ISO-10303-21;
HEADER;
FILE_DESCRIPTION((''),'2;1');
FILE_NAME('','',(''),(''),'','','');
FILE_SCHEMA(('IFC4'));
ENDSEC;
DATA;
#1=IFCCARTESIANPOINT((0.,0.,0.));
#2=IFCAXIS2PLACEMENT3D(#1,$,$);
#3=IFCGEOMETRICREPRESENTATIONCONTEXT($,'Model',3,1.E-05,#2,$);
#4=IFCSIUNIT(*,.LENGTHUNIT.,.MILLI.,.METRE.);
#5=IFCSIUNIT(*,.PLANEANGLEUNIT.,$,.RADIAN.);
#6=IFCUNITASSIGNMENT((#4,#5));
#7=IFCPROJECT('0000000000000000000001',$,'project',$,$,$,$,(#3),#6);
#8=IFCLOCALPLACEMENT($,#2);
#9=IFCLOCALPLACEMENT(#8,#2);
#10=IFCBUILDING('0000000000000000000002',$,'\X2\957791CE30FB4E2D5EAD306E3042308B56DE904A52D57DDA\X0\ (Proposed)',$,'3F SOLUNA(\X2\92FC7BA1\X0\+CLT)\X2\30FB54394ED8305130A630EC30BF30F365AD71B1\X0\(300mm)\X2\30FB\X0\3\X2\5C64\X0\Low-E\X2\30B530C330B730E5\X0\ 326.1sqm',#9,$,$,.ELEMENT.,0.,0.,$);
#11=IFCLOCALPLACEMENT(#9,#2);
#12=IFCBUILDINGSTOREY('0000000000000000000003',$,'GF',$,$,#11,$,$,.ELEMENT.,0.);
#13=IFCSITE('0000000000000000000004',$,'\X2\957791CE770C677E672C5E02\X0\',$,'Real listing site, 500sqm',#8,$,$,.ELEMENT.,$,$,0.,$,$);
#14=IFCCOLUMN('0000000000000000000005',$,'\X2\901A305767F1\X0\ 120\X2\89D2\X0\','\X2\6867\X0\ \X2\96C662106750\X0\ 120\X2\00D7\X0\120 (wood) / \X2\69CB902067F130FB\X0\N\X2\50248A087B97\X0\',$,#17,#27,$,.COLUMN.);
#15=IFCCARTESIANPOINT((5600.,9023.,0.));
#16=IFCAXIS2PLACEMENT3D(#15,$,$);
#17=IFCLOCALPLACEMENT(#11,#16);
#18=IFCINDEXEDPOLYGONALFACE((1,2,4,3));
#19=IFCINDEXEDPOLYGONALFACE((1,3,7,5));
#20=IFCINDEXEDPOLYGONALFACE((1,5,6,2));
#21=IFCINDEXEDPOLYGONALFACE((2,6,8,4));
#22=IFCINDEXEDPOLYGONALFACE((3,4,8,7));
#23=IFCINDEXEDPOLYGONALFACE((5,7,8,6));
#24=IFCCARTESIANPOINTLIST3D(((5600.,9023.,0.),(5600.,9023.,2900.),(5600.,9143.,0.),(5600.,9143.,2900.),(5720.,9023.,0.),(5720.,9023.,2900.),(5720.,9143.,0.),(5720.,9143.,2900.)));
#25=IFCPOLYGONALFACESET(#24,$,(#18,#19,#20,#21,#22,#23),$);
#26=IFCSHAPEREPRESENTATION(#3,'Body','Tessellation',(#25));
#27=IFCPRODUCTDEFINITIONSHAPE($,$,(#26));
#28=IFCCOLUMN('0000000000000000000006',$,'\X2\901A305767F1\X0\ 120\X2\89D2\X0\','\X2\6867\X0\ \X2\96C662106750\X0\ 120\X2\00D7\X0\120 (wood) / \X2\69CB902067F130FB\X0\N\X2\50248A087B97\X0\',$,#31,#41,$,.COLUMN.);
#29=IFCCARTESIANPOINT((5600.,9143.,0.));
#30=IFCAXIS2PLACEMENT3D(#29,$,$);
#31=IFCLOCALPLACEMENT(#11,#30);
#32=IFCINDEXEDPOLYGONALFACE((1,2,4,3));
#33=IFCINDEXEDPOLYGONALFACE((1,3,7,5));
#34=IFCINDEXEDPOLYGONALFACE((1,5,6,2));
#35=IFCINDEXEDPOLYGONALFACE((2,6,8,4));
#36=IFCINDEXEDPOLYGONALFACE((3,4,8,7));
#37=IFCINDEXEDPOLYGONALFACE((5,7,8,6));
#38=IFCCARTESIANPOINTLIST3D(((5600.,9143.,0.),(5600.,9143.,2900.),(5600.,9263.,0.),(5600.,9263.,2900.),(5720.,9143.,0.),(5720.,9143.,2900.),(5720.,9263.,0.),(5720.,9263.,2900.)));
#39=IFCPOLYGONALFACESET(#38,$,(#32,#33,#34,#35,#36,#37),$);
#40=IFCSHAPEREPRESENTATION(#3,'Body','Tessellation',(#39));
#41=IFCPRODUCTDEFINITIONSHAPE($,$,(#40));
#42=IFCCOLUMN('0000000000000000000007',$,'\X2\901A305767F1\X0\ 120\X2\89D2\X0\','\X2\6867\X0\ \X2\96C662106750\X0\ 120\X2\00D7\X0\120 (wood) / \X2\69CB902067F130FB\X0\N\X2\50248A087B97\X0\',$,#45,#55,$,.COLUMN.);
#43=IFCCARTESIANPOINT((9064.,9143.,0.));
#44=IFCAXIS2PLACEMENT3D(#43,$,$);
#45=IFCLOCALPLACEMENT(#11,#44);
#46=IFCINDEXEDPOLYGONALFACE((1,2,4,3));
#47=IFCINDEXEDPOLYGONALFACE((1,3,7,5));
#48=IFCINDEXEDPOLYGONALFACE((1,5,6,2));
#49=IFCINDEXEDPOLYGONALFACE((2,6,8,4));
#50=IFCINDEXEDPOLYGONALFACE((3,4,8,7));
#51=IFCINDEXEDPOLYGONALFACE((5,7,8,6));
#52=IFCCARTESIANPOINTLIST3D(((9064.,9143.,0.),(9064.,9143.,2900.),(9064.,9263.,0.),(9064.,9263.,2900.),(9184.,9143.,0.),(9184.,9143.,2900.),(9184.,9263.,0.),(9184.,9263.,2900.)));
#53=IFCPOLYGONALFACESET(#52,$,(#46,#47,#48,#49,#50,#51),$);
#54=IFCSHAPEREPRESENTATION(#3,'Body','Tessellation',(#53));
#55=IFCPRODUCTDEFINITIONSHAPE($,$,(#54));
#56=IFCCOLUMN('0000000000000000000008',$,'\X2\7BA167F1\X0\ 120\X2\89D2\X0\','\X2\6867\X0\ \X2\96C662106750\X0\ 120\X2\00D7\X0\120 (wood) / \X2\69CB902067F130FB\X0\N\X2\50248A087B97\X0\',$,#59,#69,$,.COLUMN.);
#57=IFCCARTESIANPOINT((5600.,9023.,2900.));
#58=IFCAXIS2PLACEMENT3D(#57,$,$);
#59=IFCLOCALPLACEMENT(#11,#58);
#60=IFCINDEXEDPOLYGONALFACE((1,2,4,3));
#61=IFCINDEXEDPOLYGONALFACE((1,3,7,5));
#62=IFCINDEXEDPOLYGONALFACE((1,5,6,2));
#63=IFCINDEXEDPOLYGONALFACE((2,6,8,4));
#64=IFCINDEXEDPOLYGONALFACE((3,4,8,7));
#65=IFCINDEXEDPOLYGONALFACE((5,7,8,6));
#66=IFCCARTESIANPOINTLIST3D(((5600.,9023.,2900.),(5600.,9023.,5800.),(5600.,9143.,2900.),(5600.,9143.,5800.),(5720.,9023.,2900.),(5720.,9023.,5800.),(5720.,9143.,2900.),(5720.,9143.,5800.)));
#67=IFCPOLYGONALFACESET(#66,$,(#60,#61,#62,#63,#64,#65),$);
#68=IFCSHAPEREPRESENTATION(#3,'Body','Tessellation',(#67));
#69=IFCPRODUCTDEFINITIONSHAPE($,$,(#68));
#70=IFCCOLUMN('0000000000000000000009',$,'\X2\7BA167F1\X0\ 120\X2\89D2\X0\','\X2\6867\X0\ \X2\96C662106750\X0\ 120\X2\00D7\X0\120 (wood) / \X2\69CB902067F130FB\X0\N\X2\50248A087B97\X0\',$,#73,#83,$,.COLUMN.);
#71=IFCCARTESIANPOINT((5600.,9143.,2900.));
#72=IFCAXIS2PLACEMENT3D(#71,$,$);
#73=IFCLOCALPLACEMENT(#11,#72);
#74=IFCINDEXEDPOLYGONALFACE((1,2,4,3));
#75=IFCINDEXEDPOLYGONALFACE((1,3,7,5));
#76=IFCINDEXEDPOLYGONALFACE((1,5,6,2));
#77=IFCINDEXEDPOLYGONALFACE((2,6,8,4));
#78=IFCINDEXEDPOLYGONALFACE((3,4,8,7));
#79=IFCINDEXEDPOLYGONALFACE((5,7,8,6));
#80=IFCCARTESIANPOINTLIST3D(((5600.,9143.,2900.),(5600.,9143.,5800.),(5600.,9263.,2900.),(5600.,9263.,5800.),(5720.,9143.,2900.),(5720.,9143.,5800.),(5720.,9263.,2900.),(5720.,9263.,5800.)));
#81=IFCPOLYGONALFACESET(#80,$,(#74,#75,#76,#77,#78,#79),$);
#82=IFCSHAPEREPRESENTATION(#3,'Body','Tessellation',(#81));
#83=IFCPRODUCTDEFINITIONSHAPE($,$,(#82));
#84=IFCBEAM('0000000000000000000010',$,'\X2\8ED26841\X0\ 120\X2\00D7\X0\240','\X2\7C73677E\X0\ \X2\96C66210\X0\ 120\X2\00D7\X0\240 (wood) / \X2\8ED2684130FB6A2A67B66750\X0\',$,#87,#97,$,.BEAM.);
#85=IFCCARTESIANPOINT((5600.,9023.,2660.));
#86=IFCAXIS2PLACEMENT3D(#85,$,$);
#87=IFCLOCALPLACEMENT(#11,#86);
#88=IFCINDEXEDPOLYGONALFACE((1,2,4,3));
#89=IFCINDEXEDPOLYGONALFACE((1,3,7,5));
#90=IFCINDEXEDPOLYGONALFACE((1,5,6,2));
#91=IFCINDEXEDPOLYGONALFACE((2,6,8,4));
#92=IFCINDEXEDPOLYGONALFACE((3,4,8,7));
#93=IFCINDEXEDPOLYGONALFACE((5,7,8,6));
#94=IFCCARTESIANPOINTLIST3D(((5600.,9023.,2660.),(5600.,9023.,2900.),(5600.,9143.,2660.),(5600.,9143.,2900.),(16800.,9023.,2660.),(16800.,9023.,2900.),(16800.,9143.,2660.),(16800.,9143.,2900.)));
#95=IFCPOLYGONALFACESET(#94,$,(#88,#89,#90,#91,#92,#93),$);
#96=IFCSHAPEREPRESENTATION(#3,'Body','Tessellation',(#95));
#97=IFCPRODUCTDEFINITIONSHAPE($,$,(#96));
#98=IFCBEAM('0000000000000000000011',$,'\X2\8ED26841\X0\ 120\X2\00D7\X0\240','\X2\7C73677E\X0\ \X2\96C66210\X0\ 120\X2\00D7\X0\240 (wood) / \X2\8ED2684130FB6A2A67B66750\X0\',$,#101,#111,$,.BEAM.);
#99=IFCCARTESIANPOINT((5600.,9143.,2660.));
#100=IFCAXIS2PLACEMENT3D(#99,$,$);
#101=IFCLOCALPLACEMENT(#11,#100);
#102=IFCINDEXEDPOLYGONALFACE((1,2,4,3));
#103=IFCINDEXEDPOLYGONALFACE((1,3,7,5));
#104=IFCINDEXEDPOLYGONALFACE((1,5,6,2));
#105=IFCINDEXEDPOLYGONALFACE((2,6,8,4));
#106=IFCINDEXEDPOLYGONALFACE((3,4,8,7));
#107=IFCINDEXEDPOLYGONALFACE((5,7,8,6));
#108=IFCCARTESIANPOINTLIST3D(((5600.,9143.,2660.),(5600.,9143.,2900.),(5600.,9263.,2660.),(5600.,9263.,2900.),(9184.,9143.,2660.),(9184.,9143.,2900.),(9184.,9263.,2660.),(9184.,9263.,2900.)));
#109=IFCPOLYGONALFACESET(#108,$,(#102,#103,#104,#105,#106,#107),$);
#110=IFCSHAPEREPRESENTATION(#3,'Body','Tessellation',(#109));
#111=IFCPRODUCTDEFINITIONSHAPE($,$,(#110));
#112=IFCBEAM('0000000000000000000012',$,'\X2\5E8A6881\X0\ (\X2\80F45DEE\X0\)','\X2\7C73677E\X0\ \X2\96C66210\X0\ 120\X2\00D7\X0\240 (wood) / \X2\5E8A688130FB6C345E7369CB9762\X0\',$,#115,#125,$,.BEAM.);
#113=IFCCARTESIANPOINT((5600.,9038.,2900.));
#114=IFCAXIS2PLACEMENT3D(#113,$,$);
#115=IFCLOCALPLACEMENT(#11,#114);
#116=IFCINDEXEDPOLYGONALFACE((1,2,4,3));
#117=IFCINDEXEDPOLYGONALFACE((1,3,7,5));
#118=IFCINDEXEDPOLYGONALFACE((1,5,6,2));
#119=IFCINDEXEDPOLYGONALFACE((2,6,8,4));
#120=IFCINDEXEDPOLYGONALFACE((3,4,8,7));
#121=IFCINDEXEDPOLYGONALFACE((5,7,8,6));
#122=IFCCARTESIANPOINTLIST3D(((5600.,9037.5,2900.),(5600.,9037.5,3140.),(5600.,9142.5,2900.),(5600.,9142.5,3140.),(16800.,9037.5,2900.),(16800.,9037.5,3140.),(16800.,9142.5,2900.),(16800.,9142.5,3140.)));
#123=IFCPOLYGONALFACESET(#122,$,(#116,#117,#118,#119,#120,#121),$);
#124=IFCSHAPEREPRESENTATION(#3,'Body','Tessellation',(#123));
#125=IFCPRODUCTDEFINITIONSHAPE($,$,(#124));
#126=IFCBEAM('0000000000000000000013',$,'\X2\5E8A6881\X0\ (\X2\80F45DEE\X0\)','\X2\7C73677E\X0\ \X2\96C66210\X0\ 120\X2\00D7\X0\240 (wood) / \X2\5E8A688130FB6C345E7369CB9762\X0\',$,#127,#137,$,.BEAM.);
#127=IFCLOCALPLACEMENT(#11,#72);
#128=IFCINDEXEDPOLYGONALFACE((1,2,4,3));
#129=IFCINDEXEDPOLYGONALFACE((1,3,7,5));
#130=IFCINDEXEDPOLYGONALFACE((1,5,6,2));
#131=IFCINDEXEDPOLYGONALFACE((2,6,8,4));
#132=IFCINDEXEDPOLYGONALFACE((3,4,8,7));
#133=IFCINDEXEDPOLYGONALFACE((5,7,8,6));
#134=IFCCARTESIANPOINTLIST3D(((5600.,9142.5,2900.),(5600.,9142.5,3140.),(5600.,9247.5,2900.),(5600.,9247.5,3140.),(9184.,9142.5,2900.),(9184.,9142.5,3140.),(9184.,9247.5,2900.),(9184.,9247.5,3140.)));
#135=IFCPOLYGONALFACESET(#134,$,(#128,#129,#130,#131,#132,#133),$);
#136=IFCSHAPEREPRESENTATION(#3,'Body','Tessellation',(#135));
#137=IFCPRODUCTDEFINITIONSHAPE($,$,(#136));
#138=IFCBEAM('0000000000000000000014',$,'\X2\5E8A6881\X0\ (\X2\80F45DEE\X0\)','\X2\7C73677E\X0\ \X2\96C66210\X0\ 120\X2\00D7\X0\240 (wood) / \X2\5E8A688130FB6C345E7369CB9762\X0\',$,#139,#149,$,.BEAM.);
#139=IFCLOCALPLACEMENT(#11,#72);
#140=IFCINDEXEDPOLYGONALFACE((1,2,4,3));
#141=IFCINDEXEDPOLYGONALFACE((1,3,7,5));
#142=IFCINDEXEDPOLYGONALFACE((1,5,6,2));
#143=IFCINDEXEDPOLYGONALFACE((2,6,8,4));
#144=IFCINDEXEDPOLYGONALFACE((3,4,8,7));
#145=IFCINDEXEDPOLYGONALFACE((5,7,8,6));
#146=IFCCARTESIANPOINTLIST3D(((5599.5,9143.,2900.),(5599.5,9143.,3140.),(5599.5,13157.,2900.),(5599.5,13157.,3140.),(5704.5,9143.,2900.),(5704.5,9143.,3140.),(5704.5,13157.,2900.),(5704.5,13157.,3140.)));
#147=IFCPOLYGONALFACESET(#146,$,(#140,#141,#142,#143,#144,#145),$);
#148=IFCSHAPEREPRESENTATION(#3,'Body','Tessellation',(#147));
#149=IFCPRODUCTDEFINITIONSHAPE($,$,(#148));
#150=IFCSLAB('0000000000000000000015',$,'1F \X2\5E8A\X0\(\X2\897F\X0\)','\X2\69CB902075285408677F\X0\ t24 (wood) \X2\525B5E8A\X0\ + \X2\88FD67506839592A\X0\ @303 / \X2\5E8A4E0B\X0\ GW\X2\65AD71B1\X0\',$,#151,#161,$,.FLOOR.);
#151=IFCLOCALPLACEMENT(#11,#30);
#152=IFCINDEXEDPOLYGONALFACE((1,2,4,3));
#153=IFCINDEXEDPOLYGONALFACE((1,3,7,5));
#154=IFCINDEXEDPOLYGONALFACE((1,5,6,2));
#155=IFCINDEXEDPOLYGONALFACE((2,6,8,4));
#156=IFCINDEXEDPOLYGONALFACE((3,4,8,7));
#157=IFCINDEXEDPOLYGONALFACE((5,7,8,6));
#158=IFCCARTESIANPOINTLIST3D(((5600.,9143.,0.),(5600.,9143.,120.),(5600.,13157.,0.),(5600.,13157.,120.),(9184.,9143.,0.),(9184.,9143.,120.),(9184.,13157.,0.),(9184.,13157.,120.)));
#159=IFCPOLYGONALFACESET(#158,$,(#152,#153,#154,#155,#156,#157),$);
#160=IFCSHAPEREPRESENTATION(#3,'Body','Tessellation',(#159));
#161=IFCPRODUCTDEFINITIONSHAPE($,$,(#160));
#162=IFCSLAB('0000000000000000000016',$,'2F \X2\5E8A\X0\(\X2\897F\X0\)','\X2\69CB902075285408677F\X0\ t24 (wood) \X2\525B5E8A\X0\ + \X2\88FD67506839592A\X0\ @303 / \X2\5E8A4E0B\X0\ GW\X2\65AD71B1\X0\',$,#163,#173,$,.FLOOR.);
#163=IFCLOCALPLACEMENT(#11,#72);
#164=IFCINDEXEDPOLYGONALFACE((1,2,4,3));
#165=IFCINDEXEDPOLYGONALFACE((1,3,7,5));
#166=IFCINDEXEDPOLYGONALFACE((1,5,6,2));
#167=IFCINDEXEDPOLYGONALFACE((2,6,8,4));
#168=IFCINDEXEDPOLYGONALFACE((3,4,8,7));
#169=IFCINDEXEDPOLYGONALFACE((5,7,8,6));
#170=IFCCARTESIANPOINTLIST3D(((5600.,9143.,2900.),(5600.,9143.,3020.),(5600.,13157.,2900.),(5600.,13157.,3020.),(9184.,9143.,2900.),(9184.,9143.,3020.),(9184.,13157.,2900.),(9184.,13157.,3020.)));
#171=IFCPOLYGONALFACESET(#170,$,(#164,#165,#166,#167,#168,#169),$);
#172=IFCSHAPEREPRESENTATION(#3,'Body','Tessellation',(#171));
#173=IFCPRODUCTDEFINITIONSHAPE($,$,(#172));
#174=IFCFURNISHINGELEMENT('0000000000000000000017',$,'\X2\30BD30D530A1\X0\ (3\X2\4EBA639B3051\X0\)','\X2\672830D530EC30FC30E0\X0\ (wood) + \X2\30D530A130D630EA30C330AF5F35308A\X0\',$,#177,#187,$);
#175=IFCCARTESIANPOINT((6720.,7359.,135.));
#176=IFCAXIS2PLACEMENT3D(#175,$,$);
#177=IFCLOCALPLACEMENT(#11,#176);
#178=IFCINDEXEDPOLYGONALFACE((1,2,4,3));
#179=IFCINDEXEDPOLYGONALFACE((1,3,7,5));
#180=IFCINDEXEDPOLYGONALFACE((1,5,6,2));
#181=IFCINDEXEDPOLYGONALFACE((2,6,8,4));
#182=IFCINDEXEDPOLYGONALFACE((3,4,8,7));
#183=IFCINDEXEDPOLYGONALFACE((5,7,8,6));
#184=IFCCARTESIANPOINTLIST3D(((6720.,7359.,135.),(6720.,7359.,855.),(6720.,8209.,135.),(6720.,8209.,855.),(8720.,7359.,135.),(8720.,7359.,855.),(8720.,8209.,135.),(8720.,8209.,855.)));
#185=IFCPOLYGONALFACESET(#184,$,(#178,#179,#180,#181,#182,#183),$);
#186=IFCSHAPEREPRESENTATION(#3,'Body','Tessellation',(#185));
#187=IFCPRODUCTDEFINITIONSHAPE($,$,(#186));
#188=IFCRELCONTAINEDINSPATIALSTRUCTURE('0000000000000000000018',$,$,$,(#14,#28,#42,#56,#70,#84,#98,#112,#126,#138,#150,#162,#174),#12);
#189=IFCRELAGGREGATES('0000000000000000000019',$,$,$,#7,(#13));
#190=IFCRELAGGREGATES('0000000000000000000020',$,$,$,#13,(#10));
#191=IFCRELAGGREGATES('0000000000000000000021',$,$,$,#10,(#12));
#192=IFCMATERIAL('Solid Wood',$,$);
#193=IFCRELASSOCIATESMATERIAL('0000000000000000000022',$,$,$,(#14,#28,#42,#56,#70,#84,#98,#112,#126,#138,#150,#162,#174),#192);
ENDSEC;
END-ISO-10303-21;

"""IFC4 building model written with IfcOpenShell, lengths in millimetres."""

from ifc_helpers import new_model, si_unit, frame, frame_2d, origin, place, context, project, spatial, rectangle, extrude, material, element, save


model = new_model("IFC4")

# Units and contexts
model_context = context("Model", 3, precision=1e-05, world=origin())
ifc_project = project(units=[si_unit("LENGTHUNIT", "METRE", prefix="MILLI"), si_unit("PLANEANGLEUNIT", "RADIAN")], contexts=[model_context])

# Site, building, storey
site_placement = place(None, origin())
site = spatial("IfcSite", under=ifc_project, at=site_placement, Name="長野県松本市", ObjectType="Real listing site, 500sqm", CompositionType="ELEMENT", RefElevation=0.0)
building_placement = place(site_placement, origin())
building = spatial("IfcBuilding", under=site, at=building_placement, Name="長野・中庭のある回遊動線 (Proposed)", ObjectType="3F SOLUNA(鋼管+CLT)・吹付けウレタン断熱(300mm)・3層Low-Eサッシュ 326.1sqm", CompositionType="ELEMENT", ElevationOfRefHeight=0.0, ElevationOfTerrain=0.0)
storey_placement = place(building_placement, origin())
storey = spatial("IfcBuildingStorey", under=building, at=storey_placement, Name="GF", CompositionType="ELEMENT", Elevation=0.0)

# Columns
ifc_material = material(Name="Solid Wood")
column_1_placement = place(storey_placement, frame((5600.0, 9023.0, 0.0)))
element("IfcColumn", 1, at=column_1_placement, inside=storey, material=ifc_material, Name="通し柱 120角", Description="桧 集成材 120×120 (wood) / 構造柱・N値計算", PredefinedType="COLUMN", context=model_context, shape_type="SweptSolid", body=[
    extrude(rectangle(XDim=120.0, YDim=120.0, at=frame_2d((60.0, 60.0))), frame((5600.0, 9023.0, 0.0)), (0.0, 0.0, 1.0), 2900.0),
])
column_2_placement = place(storey_placement, frame((5600.0, 9143.0, 0.0)))
element("IfcColumn", 2, at=column_2_placement, inside=storey, material=ifc_material, Name="通し柱 120角", Description="桧 集成材 120×120 (wood) / 構造柱・N値計算", PredefinedType="COLUMN", context=model_context, shape_type="SweptSolid", body=[
    extrude(rectangle(XDim=120.0, YDim=120.0, at=frame_2d((60.0, 60.0))), frame((5600.0, 9143.0, 0.0)), (0.0, 0.0, 1.0), 2900.0),
])
column_3_placement = place(storey_placement, frame((9064.0, 9143.0, 0.0)))
element("IfcColumn", 3, at=column_3_placement, inside=storey, material=ifc_material, Name="通し柱 120角", Description="桧 集成材 120×120 (wood) / 構造柱・N値計算", PredefinedType="COLUMN", context=model_context, shape_type="SweptSolid", body=[
    extrude(rectangle(XDim=120.0, YDim=120.0, at=frame_2d((60.0, 60.0))), frame((9064.0, 9143.0, 0.0)), (0.0, 0.0, 1.0), 2900.0),
])
column_4_placement = place(storey_placement, frame((5600.0, 9023.0, 2900.0)))
element("IfcColumn", 4, at=column_4_placement, inside=storey, material=ifc_material, Name="管柱 120角", Description="桧 集成材 120×120 (wood) / 構造柱・N値計算", PredefinedType="COLUMN", context=model_context, shape_type="SweptSolid", body=[
    extrude(rectangle(XDim=120.0, YDim=120.0, at=frame_2d((60.0, 60.0))), frame((5600.0, 9023.0, 2900.0)), (0.0, 0.0, 1.0), 2900.0),
])
column_5_placement = place(storey_placement, frame((5600.0, 9143.0, 2900.0)))
element("IfcColumn", 5, at=column_5_placement, inside=storey, material=ifc_material, Name="管柱 120角", Description="桧 集成材 120×120 (wood) / 構造柱・N値計算", PredefinedType="COLUMN", context=model_context, shape_type="SweptSolid", body=[
    extrude(rectangle(XDim=120.0, YDim=120.0, at=frame_2d((60.0, 60.0))), frame((5600.0, 9143.0, 2900.0)), (0.0, 0.0, 1.0), 2900.0),
])

# Beams
beam_1_placement = place(storey_placement, frame((5600.0, 9023.0, 2660.0)))
element("IfcBeam", 6, at=beam_1_placement, inside=storey, material=ifc_material, Name="軒桁 120×240", Description="米松 集成 120×240 (wood) / 軒桁・横架材", PredefinedType="BEAM", context=model_context, shape_type="SweptSolid", body=[
    extrude(rectangle(XDim=11200.0, YDim=120.0, at=frame_2d((5600.0, 60.0))), frame((5600.0, 9023.0, 2660.0)), (0.0, 0.0, 1.0), 240.0),
])
beam_2_placement = place(storey_placement, frame((5600.0, 9143.0, 2660.0)))
element("IfcBeam", 7, at=beam_2_placement, inside=storey, material=ifc_material, Name="軒桁 120×240", Description="米松 集成 120×240 (wood) / 軒桁・横架材", PredefinedType="BEAM", context=model_context, shape_type="SweptSolid", body=[
    extrude(rectangle(XDim=3584.0, YDim=120.0, at=frame_2d((1792.0, 60.0))), frame((5600.0, 9143.0, 2660.0)), (0.0, 0.0, 1.0), 240.0),
])
beam_3_placement = place(storey_placement, frame((5600.0, 9038.0, 2900.0)))
element("IfcBeam", 8, at=beam_3_placement, inside=storey, material=ifc_material, Name="床梁 (胴差)", Description="米松 集成 120×240 (wood) / 床梁・水平構面", PredefinedType="BEAM", context=model_context, shape_type="SweptSolid", body=[
    extrude(rectangle(XDim=11200.0, YDim=105.0, at=frame_2d((5600.0, 52.0))), frame((5600.0, 9038.0, 2900.0)), (0.0, 0.0, 1.0), 240.0),
])
beam_4_placement = place(storey_placement, frame((5600.0, 9143.0, 2900.0)))
element("IfcBeam", 9, at=beam_4_placement, inside=storey, material=ifc_material, Name="床梁 (胴差)", Description="米松 集成 120×240 (wood) / 床梁・水平構面", PredefinedType="BEAM", context=model_context, shape_type="SweptSolid", body=[
    extrude(rectangle(XDim=3584.0, YDim=105.0, at=frame_2d((1792.0, 52.0))), frame((5600.0, 9143.0, 2900.0)), (0.0, 0.0, 1.0), 240.0),
])
beam_5_placement = place(storey_placement, frame((5600.0, 9143.0, 2900.0)))
element("IfcBeam", 10, at=beam_5_placement, inside=storey, material=ifc_material, Name="床梁 (胴差)", Description="米松 集成 120×240 (wood) / 床梁・水平構面", PredefinedType="BEAM", context=model_context, shape_type="SweptSolid", body=[
    extrude(rectangle(XDim=105.0, YDim=4014.0, at=frame_2d((52.0, 2007.0))), frame((5600.0, 9143.0, 2900.0)), (0.0, 0.0, 1.0), 240.0),
])

# Slabs
slab_1_placement = place(storey_placement, frame((5600.0, 9143.0, 0.0)))
element("IfcSlab", 11, at=slab_1_placement, inside=storey, material=ifc_material, Name="1F 床(西)", Description="構造用合板 t24 (wood) 剛床 + 製材根太 @303 / 床下 GW断熱", PredefinedType="FLOOR", context=model_context, shape_type="SweptSolid", body=[
    extrude(rectangle(XDim=3584.0, YDim=4014.0, at=frame_2d((1792.0, 2007.0))), frame((5600.0, 9143.0, 0.0)), (0.0, 0.0, 1.0), 120.0),
])
slab_2_placement = place(storey_placement, frame((5600.0, 9143.0, 2900.0)))
element("IfcSlab", 12, at=slab_2_placement, inside=storey, material=ifc_material, Name="2F 床(西)", Description="構造用合板 t24 (wood) 剛床 + 製材根太 @303 / 床下 GW断熱", PredefinedType="FLOOR", context=model_context, shape_type="SweptSolid", body=[
    extrude(rectangle(XDim=3584.0, YDim=4014.0, at=frame_2d((1792.0, 2007.0))), frame((5600.0, 9143.0, 2900.0)), (0.0, 0.0, 1.0), 120.0),
])

# Furnishing element
furnishing_placement = place(storey_placement, frame((6720.0, 7359.0, 135.0)))
element("IfcFurnishingElement", 13, at=furnishing_placement, inside=storey, material=ifc_material, Name="ソファ (3人掛け)", Description="木フレーム (wood) + ファブリック張り", context=model_context, shape_type="SweptSolid", body=[
    extrude(rectangle(XDim=2000.0, YDim=850.0, at=frame_2d((1000.0, 425.0))), frame((6720.0, 7359.0, 135.0)), (0.0, 0.0, 1.0), 720.0),
])

save(model, "model.ifc")
